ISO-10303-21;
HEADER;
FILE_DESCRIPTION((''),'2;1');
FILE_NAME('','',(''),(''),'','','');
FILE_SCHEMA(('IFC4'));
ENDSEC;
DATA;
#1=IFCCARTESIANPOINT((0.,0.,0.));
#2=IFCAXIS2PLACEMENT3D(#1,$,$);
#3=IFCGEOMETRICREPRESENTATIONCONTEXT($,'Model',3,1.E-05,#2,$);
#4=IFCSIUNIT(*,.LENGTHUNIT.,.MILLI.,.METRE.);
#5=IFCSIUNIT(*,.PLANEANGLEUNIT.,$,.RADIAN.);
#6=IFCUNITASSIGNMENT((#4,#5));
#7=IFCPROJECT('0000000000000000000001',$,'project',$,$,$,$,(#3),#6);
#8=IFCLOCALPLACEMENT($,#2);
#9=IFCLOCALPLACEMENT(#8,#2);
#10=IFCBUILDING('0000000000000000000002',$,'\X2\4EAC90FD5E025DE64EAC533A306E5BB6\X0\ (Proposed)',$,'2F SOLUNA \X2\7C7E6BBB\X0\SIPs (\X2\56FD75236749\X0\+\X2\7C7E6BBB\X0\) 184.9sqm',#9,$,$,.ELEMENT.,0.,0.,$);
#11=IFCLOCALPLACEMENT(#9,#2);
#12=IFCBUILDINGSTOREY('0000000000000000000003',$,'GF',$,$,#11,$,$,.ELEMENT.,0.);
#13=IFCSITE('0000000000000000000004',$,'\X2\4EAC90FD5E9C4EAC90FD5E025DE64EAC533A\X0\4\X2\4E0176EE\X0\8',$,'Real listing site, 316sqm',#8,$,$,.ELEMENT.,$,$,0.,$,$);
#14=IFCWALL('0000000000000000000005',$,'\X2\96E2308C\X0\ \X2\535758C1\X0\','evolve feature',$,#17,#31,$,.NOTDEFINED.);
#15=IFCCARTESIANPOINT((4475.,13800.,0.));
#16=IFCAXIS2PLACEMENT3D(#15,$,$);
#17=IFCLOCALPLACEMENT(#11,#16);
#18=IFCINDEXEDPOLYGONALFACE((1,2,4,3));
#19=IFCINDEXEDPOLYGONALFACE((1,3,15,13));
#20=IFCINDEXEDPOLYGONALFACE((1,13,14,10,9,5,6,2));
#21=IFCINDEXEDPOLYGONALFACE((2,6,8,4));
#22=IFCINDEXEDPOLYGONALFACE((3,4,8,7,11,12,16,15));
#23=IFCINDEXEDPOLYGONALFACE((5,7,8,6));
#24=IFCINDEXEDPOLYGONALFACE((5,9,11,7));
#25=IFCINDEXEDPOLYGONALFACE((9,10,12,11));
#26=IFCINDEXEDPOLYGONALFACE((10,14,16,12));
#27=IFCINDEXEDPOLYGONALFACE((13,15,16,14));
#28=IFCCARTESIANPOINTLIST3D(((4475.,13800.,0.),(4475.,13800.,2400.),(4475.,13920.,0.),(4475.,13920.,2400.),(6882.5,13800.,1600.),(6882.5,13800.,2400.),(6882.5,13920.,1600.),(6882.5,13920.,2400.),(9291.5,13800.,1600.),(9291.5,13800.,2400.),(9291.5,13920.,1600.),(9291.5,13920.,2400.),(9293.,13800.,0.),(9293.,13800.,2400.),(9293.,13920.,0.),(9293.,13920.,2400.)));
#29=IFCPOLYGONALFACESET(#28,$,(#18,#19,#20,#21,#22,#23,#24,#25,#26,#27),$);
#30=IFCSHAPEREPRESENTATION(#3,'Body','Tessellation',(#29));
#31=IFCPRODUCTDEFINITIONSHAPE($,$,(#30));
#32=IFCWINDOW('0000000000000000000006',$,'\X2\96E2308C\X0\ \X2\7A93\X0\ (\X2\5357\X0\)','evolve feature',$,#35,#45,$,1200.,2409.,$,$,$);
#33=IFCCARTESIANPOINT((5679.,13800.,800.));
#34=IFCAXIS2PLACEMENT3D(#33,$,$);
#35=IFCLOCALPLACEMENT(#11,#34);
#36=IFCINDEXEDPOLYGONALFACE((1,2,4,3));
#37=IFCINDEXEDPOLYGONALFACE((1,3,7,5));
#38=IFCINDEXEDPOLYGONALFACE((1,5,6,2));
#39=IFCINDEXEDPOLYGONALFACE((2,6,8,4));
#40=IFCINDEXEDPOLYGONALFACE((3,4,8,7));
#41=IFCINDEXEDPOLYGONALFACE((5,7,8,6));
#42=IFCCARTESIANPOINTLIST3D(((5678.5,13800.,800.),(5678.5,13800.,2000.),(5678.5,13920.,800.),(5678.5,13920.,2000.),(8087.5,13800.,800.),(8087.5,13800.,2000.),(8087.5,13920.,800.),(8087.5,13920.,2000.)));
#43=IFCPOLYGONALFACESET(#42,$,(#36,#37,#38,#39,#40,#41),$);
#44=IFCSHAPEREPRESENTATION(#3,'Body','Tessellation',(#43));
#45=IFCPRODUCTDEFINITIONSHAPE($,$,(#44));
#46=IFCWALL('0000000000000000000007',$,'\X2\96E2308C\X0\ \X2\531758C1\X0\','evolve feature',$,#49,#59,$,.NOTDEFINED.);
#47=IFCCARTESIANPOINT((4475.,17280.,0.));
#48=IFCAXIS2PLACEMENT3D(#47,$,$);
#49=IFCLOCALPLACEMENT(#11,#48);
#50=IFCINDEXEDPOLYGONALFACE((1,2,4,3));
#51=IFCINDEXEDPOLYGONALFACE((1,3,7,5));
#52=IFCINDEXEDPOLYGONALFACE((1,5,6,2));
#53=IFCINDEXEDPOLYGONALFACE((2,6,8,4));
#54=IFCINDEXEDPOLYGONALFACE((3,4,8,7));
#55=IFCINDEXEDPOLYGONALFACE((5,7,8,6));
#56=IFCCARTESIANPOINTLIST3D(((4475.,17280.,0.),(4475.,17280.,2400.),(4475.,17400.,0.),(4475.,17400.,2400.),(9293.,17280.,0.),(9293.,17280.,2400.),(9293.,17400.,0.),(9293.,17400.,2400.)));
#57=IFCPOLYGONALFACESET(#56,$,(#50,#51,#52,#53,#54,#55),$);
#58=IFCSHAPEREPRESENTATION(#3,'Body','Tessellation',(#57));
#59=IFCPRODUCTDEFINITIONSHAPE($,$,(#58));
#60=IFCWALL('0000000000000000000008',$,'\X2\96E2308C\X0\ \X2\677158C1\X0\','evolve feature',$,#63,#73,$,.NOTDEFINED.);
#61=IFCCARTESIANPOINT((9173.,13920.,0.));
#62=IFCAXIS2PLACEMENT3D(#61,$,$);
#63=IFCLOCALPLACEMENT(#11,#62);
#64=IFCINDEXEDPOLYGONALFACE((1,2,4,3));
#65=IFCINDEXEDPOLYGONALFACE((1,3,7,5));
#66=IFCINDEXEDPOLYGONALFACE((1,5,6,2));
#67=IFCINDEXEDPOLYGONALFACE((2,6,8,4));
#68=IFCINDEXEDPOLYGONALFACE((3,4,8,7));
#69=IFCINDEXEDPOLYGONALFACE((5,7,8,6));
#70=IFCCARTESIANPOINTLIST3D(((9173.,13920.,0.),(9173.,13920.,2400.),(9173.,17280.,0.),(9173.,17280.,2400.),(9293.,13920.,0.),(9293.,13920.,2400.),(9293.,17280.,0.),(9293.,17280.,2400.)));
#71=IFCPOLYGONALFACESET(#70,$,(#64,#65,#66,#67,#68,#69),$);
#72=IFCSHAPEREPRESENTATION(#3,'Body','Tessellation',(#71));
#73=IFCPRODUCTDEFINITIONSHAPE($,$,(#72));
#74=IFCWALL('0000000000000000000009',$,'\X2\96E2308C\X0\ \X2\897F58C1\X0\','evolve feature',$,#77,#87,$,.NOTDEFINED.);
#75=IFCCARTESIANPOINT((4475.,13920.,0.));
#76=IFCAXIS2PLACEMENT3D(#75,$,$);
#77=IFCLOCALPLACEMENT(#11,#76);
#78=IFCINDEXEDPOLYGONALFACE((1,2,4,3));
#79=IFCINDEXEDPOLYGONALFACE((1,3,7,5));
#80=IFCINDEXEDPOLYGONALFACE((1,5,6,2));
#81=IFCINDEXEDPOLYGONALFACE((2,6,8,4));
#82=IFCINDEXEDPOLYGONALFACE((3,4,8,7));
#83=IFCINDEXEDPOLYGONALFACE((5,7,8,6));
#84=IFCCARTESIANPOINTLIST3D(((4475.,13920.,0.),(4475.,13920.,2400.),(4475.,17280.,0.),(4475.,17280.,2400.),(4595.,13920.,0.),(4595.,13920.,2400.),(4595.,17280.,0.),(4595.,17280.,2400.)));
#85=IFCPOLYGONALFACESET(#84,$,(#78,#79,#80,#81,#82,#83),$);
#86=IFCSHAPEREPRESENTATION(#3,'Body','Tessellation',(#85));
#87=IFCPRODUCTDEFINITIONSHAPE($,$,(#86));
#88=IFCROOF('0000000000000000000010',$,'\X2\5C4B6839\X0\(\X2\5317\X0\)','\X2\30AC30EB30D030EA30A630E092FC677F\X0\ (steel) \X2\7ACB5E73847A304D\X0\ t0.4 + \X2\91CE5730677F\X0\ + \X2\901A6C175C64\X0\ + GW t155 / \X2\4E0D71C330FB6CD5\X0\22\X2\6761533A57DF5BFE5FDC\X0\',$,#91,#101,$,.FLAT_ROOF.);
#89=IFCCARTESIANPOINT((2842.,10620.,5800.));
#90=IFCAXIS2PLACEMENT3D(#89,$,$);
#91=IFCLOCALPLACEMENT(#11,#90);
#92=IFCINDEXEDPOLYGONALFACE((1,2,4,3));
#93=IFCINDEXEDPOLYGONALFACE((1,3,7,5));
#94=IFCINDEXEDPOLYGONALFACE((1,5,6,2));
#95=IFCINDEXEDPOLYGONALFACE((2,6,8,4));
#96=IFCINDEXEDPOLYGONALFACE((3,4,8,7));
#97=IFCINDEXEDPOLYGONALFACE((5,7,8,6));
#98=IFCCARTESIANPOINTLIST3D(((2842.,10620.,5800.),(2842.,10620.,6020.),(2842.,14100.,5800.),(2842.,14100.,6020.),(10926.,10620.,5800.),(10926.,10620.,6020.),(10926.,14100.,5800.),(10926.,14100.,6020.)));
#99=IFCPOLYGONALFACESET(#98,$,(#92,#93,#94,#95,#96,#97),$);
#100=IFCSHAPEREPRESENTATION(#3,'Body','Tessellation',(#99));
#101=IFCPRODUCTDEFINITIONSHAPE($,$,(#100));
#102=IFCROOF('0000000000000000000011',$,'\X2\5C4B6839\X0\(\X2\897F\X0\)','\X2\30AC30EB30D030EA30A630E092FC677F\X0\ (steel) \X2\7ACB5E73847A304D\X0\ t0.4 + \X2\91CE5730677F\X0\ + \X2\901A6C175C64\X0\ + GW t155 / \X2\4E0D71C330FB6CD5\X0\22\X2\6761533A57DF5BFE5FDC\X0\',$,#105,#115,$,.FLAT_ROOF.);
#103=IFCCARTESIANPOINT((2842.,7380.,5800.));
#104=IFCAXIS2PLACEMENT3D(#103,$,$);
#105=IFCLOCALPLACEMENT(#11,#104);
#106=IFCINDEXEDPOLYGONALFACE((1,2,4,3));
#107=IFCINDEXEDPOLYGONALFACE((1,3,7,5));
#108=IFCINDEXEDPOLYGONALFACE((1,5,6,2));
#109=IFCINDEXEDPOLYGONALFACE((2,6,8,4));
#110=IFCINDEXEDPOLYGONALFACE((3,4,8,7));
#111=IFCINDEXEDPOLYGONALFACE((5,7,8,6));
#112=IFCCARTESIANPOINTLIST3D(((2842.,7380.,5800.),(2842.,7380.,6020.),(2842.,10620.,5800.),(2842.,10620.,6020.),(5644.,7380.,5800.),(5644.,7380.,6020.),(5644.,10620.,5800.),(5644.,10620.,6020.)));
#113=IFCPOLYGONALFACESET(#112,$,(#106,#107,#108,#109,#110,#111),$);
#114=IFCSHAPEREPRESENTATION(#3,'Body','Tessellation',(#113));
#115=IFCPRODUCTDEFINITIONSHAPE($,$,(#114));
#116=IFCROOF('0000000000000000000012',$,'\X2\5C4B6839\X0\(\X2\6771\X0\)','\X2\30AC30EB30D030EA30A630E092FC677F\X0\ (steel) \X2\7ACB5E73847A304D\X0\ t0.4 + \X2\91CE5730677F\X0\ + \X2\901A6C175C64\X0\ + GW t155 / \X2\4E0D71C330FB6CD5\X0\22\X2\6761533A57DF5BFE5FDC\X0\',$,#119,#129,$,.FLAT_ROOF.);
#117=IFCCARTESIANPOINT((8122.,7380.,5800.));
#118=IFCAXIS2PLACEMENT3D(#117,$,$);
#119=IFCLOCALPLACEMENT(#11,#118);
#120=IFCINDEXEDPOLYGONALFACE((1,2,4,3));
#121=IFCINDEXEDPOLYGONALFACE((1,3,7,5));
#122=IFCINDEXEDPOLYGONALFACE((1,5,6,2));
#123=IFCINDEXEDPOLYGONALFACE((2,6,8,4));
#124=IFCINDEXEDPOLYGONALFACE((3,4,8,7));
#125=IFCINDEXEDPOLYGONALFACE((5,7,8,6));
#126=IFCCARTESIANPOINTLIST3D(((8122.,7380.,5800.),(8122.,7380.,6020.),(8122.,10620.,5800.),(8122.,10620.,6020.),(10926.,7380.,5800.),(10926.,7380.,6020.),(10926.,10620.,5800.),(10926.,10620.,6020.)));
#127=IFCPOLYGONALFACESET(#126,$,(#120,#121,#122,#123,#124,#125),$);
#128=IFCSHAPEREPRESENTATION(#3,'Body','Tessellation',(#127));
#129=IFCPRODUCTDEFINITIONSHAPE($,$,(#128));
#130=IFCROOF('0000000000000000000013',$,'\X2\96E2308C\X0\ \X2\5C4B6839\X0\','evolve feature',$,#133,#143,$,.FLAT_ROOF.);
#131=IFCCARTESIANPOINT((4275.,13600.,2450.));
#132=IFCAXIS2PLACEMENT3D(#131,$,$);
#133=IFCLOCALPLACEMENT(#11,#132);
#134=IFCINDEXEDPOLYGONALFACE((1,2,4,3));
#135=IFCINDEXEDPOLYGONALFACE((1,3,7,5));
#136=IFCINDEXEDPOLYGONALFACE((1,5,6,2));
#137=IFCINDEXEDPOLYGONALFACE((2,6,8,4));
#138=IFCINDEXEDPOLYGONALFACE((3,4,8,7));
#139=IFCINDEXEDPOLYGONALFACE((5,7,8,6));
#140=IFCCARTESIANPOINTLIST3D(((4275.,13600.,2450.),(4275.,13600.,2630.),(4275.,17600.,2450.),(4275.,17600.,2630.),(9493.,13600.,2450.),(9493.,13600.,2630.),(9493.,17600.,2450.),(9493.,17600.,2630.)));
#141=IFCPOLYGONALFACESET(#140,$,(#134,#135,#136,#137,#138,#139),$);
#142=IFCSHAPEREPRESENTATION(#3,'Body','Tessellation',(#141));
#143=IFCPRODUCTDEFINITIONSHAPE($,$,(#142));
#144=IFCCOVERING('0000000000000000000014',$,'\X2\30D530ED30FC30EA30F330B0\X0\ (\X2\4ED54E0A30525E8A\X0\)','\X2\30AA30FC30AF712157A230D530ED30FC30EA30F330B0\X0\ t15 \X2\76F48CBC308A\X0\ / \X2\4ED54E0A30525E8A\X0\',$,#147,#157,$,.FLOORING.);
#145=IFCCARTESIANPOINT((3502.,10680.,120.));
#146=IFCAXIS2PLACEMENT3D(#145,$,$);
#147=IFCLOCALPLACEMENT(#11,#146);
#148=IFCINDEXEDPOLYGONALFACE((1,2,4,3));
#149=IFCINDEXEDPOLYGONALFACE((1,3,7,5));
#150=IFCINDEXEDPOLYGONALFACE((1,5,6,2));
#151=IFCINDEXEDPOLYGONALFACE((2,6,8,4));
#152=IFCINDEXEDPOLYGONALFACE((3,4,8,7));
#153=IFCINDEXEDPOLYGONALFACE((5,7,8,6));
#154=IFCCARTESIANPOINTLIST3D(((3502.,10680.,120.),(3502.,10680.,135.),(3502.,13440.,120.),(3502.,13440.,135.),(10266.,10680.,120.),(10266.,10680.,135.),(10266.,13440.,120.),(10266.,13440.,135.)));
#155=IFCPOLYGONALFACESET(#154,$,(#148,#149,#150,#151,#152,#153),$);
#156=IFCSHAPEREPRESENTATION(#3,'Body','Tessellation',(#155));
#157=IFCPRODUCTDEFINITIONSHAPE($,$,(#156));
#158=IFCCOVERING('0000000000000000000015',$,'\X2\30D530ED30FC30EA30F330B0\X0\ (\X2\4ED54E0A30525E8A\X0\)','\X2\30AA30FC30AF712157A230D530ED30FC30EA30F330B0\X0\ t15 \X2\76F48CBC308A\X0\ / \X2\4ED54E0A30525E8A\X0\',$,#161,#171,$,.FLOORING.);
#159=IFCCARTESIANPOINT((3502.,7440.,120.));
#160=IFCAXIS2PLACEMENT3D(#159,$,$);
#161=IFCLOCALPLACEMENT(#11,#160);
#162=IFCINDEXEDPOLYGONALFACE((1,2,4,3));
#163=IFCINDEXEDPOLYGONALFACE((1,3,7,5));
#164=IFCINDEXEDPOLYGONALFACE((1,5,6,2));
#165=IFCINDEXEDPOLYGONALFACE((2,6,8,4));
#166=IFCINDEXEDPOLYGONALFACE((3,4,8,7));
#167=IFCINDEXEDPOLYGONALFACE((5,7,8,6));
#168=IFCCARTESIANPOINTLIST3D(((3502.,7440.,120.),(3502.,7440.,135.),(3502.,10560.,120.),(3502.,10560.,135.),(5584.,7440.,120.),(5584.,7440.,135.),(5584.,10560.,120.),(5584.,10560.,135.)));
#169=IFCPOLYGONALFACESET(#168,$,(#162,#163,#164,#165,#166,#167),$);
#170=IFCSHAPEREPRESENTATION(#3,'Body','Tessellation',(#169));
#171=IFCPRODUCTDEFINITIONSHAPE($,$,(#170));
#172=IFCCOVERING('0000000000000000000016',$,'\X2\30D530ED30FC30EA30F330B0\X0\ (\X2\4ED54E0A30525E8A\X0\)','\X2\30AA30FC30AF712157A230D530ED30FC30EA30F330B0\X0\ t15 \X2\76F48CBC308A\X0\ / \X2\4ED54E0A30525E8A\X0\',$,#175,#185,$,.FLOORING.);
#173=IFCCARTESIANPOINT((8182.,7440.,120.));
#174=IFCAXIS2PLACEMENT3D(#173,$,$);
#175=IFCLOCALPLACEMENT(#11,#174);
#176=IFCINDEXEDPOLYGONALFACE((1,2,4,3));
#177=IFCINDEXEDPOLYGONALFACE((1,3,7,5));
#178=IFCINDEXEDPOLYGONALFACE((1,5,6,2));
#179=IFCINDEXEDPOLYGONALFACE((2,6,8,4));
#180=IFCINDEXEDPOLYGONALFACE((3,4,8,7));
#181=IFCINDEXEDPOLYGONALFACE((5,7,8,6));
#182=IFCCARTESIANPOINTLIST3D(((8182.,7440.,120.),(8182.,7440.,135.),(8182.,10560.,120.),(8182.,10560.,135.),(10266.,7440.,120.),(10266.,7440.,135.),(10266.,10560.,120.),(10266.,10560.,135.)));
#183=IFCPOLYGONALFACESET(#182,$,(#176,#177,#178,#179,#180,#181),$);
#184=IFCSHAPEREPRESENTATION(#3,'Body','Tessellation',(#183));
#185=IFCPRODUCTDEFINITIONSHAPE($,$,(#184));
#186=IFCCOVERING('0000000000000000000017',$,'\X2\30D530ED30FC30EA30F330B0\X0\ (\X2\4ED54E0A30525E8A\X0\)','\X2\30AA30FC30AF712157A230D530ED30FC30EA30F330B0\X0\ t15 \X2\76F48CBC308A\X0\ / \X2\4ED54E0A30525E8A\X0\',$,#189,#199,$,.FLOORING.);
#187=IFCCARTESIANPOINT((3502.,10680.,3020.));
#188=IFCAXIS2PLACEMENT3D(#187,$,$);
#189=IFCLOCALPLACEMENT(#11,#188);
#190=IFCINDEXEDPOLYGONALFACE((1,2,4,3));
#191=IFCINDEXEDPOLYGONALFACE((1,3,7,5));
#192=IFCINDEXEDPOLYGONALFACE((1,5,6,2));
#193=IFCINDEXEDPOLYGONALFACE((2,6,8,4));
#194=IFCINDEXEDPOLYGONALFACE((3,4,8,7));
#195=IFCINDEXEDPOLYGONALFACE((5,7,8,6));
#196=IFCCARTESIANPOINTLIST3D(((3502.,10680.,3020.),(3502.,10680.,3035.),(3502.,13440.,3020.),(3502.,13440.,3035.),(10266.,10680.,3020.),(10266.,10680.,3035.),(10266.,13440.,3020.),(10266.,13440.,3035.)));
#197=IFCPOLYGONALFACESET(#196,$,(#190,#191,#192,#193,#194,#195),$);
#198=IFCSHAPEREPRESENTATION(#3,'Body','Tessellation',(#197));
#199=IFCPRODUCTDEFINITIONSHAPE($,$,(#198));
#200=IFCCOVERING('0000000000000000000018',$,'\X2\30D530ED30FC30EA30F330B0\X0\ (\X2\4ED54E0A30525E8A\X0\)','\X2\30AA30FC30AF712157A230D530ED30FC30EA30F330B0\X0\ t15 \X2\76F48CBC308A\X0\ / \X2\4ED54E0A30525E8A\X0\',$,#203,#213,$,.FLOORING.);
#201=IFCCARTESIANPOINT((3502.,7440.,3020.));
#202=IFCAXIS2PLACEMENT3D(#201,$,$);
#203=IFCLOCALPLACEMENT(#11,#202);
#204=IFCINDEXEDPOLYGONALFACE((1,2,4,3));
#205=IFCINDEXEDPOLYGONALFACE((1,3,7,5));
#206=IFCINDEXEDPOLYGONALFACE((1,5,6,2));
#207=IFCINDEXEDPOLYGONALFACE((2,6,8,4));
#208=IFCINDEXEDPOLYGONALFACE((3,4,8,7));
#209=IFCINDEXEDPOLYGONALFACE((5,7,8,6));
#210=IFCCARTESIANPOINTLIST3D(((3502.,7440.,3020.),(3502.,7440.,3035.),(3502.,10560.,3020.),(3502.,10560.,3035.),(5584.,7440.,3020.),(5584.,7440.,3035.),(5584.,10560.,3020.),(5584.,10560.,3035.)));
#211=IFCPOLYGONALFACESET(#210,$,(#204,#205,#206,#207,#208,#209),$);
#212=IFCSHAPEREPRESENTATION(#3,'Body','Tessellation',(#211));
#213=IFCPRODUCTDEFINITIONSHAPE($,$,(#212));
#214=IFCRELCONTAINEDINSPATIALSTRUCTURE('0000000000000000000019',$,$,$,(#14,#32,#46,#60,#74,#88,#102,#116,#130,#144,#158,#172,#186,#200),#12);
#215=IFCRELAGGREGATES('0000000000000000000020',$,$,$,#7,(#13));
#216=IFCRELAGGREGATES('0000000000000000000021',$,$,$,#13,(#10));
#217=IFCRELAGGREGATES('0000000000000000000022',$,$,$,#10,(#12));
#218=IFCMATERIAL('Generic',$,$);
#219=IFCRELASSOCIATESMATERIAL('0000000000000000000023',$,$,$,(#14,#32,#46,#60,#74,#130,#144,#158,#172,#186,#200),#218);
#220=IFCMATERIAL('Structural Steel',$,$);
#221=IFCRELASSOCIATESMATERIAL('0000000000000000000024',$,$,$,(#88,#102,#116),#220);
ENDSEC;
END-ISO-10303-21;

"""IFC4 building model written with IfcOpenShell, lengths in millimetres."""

from ifc_helpers import new_model, si_unit, frame, frame_2d, origin, place, context, project, spatial, rectangle, extrude, material, element, fill, save


model = new_model("IFC4")

# Units and contexts
model_context = context("Model", 3, precision=1e-05, world=origin())
ifc_project = project(units=[si_unit("LENGTHUNIT", "METRE", prefix="MILLI"), si_unit("PLANEANGLEUNIT", "RADIAN")], contexts=[model_context])

# Site, building, storey
site_placement = place(None, origin())
site = spatial("IfcSite", under=ifc_project, at=site_placement, Name="京都府京都市左京区4丁目8", ObjectType="Real listing site, 316sqm", CompositionType="ELEMENT", RefElevation=0.0)
building_placement = place(site_placement, origin())
building = spatial("IfcBuilding", under=site, at=building_placement, Name="京都市左京区の家 (Proposed)", ObjectType="2F SOLUNA 籾殻SIPs (国産杉+籾殻) 184.9sqm", CompositionType="ELEMENT", ElevationOfRefHeight=0.0, ElevationOfTerrain=0.0)
storey_placement = place(building_placement, origin())
storey = spatial("IfcBuildingStorey", under=building, at=storey_placement, Name="GF", CompositionType="ELEMENT", Elevation=0.0)

# Shared definitions
ifc_material_1 = material(Name="Generic")

# Wall, opening, window
wall_1_placement = place(storey_placement, frame((4475.0, 13800.0, 0.0)))
wall_1 = element("IfcWall", 1, at=wall_1_placement, inside=storey, material=ifc_material_1, Name="離れ 南壁", Description="evolve feature", PredefinedType="NOTDEFINED", context=model_context, shape_type="SweptSolid", body=[
    extrude(rectangle(XDim=4818.0, YDim=120.0, at=frame_2d((2409.0, 60.0))), frame((4475.0, 13800.0, 0.0)), (0.0, 0.0, 1.0), 2400.0),
])
opening_1_placement = place(storey_placement, frame((5679.0, 13800.0, 800.0)))
opening_1 = element("IfcOpeningElement", 2, at=opening_1_placement, cuts=wall_1, PredefinedType="NOTDEFINED", context=model_context, shape_type="SweptSolid", body=[
    extrude(rectangle(XDim=2409.0, YDim=120.0, at=frame_2d((1204.0, 60.0))), frame((5679.0, 13800.0, 800.0)), (0.0, 0.0, 1.0), 1200.0),
])
window_1_placement = place(storey_placement, frame((5679.0, 13800.0, 800.0)))
window_1 = element("IfcWindow", 3, at=window_1_placement, inside=storey, material=ifc_material_1, Name="離れ 窓 (南)", Description="evolve feature", OverallHeight=1200.0, OverallWidth=2409.0, context=model_context, shape_type="SweptSolid", body=[
    extrude(rectangle(XDim=2409.0, YDim=120.0, at=frame_2d((1204.0, 60.0))), frame((5679.0, 13800.0, 800.0)), (0.0, 0.0, 1.0), 1200.0),
])
fill(opening_1, window_1)

# Walls
wall_2_placement = place(storey_placement, frame((4475.0, 17280.0, 0.0)))
element("IfcWall", 4, at=wall_2_placement, inside=storey, material=ifc_material_1, Name="離れ 北壁", Description="evolve feature", PredefinedType="NOTDEFINED", context=model_context, shape_type="SweptSolid", body=[
    extrude(rectangle(XDim=4818.0, YDim=120.0, at=frame_2d((2409.0, 60.0))), frame((4475.0, 17280.0, 0.0)), (0.0, 0.0, 1.0), 2400.0),
])
wall_3_placement = place(storey_placement, frame((9173.0, 13920.0, 0.0)))
element("IfcWall", 5, at=wall_3_placement, inside=storey, material=ifc_material_1, Name="離れ 東壁", Description="evolve feature", PredefinedType="NOTDEFINED", context=model_context, shape_type="SweptSolid", body=[
    extrude(rectangle(XDim=120.0, YDim=3360.0, at=frame_2d((60.0, 1680.0))), frame((9173.0, 13920.0, 0.0)), (0.0, 0.0, 1.0), 2400.0),
])
wall_4_placement = place(storey_placement, frame((4475.0, 13920.0, 0.0)))
element("IfcWall", 6, at=wall_4_placement, inside=storey, material=ifc_material_1, Name="離れ 西壁", Description="evolve feature", PredefinedType="NOTDEFINED", context=model_context, shape_type="SweptSolid", body=[
    extrude(rectangle(XDim=120.0, YDim=3360.0, at=frame_2d((60.0, 1680.0))), frame((4475.0, 13920.0, 0.0)), (0.0, 0.0, 1.0), 2400.0),
])

# Roofs
ifc_material_2 = material(Name="Structural Steel")
for number, where, name in (
    (7, (2842.0, 10620.0, 5800.0), "屋根(北)"),
):
    element("IfcRoof", number, at=place(storey_placement, frame(where)), inside=storey, material=ifc_material_2, Name=name, Description="ガルバリウム鋼板 (steel) 立平葺き t0.4 + 野地板 + 通気層 + GW t155 / 不燃・法22条区域対応", PredefinedType="FLAT_ROOF", context=model_context, shape_type="SweptSolid", body=[
        extrude(rectangle(XDim=8084.0, YDim=3480.0, at=frame_2d((4042.0, 1740.0))), frame((2842.0, 10620.0, 5800.0)), (0.0, 0.0, 1.0), 220.0),
    ])
roof_1_placement = place(storey_placement, frame((2842.0, 7380.0, 5800.0)))
element("IfcRoof", 8, at=roof_1_placement, inside=storey, material=ifc_material_2, Name="屋根(西)", Description="ガルバリウム鋼板 (steel) 立平葺き t0.4 + 野地板 + 通気層 + GW t155 / 不燃・法22条区域対応", PredefinedType="FLAT_ROOF", context=model_context, shape_type="SweptSolid", body=[
    extrude(rectangle(XDim=2802.0, YDim=3240.0, at=frame_2d((1401.0, 1620.0))), frame((2842.0, 7380.0, 5800.0)), (0.0, 0.0, 1.0), 220.0),
])
roof_2_placement = place(storey_placement, frame((8122.0, 7380.0, 5800.0)))
element("IfcRoof", 9, at=roof_2_placement, inside=storey, material=ifc_material_2, Name="屋根(東)", Description="ガルバリウム鋼板 (steel) 立平葺き t0.4 + 野地板 + 通気層 + GW t155 / 不燃・法22条区域対応", PredefinedType="FLAT_ROOF", context=model_context, shape_type="SweptSolid", body=[
    extrude(rectangle(XDim=2804.0, YDim=3240.0, at=frame_2d((1402.0, 1620.0))), frame((8122.0, 7380.0, 5800.0)), (0.0, 0.0, 1.0), 220.0),
])
roof_3_placement = place(storey_placement, frame((4275.0, 13600.0, 2450.0)))
element("IfcRoof", 10, at=roof_3_placement, inside=storey, material=ifc_material_1, Name="離れ 屋根", Description="evolve feature", PredefinedType="FLAT_ROOF", context=model_context, shape_type="SweptSolid", body=[
    extrude(rectangle(XDim=5218.0, YDim=4000.0, at=frame_2d((2609.0, 2000.0))), frame((4275.0, 13600.0, 2450.0)), (0.0, 0.0, 1.0), 180.0),
])

# Coverings
covering_1_placement = place(storey_placement, frame((3502.0, 10680.0, 120.0)))
element("IfcCovering", 11, at=covering_1_placement, inside=storey, material=ifc_material_1, Name="フローリング (仕上げ床)", Description="オーク無垢フローリング t15 直貼り / 仕上げ床", PredefinedType="FLOORING", context=model_context, shape_type="SweptSolid", body=[
    extrude(rectangle(XDim=6764.0, YDim=2760.0, at=frame_2d((3382.0, 1380.0))), frame((3502.0, 10680.0, 120.0)), (0.0, 0.0, 1.0), 15.0),
])
covering_2_placement = place(storey_placement, frame((3502.0, 7440.0, 120.0)))
element("IfcCovering", 12, at=covering_2_placement, inside=storey, material=ifc_material_1, Name="フローリング (仕上げ床)", Description="オーク無垢フローリング t15 直貼り / 仕上げ床", PredefinedType="FLOORING", context=model_context, shape_type="SweptSolid", body=[
    extrude(rectangle(XDim=2082.0, YDim=3120.0, at=frame_2d((1041.0, 1560.0))), frame((3502.0, 7440.0, 120.0)), (0.0, 0.0, 1.0), 15.0),
])
covering_3_placement = place(storey_placement, frame((8182.0, 7440.0, 120.0)))
element("IfcCovering", 13, at=covering_3_placement, inside=storey, material=ifc_material_1, Name="フローリング (仕上げ床)", Description="オーク無垢フローリング t15 直貼り / 仕上げ床", PredefinedType="FLOORING", context=model_context, shape_type="SweptSolid", body=[
    extrude(rectangle(XDim=2084.0, YDim=3120.0, at=frame_2d((1042.0, 1560.0))), frame((8182.0, 7440.0, 120.0)), (0.0, 0.0, 1.0), 15.0),
])
covering_4_placement = place(storey_placement, frame((3502.0, 10680.0, 3020.0)))
element("IfcCovering", 14, at=covering_4_placement, inside=storey, material=ifc_material_1, Name="フローリング (仕上げ床)", Description="オーク無垢フローリング t15 直貼り / 仕上げ床", PredefinedType="FLOORING", context=model_context, shape_type="SweptSolid", body=[
    extrude(rectangle(XDim=6764.0, YDim=2760.0, at=frame_2d((3382.0, 1380.0))), frame((3502.0, 10680.0, 3020.0)), (0.0, 0.0, 1.0), 15.0),
])
covering_5_placement = place(storey_placement, frame((3502.0, 7440.0, 3020.0)))
element("IfcCovering", 15, at=covering_5_placement, inside=storey, material=ifc_material_1, Name="フローリング (仕上げ床)", Description="オーク無垢フローリング t15 直貼り / 仕上げ床", PredefinedType="FLOORING", context=model_context, shape_type="SweptSolid", body=[
    extrude(rectangle(XDim=2082.0, YDim=3120.0, at=frame_2d((1041.0, 1560.0))), frame((3502.0, 7440.0, 3020.0)), (0.0, 0.0, 1.0), 15.0),
])

save(model, "model.ifc")
